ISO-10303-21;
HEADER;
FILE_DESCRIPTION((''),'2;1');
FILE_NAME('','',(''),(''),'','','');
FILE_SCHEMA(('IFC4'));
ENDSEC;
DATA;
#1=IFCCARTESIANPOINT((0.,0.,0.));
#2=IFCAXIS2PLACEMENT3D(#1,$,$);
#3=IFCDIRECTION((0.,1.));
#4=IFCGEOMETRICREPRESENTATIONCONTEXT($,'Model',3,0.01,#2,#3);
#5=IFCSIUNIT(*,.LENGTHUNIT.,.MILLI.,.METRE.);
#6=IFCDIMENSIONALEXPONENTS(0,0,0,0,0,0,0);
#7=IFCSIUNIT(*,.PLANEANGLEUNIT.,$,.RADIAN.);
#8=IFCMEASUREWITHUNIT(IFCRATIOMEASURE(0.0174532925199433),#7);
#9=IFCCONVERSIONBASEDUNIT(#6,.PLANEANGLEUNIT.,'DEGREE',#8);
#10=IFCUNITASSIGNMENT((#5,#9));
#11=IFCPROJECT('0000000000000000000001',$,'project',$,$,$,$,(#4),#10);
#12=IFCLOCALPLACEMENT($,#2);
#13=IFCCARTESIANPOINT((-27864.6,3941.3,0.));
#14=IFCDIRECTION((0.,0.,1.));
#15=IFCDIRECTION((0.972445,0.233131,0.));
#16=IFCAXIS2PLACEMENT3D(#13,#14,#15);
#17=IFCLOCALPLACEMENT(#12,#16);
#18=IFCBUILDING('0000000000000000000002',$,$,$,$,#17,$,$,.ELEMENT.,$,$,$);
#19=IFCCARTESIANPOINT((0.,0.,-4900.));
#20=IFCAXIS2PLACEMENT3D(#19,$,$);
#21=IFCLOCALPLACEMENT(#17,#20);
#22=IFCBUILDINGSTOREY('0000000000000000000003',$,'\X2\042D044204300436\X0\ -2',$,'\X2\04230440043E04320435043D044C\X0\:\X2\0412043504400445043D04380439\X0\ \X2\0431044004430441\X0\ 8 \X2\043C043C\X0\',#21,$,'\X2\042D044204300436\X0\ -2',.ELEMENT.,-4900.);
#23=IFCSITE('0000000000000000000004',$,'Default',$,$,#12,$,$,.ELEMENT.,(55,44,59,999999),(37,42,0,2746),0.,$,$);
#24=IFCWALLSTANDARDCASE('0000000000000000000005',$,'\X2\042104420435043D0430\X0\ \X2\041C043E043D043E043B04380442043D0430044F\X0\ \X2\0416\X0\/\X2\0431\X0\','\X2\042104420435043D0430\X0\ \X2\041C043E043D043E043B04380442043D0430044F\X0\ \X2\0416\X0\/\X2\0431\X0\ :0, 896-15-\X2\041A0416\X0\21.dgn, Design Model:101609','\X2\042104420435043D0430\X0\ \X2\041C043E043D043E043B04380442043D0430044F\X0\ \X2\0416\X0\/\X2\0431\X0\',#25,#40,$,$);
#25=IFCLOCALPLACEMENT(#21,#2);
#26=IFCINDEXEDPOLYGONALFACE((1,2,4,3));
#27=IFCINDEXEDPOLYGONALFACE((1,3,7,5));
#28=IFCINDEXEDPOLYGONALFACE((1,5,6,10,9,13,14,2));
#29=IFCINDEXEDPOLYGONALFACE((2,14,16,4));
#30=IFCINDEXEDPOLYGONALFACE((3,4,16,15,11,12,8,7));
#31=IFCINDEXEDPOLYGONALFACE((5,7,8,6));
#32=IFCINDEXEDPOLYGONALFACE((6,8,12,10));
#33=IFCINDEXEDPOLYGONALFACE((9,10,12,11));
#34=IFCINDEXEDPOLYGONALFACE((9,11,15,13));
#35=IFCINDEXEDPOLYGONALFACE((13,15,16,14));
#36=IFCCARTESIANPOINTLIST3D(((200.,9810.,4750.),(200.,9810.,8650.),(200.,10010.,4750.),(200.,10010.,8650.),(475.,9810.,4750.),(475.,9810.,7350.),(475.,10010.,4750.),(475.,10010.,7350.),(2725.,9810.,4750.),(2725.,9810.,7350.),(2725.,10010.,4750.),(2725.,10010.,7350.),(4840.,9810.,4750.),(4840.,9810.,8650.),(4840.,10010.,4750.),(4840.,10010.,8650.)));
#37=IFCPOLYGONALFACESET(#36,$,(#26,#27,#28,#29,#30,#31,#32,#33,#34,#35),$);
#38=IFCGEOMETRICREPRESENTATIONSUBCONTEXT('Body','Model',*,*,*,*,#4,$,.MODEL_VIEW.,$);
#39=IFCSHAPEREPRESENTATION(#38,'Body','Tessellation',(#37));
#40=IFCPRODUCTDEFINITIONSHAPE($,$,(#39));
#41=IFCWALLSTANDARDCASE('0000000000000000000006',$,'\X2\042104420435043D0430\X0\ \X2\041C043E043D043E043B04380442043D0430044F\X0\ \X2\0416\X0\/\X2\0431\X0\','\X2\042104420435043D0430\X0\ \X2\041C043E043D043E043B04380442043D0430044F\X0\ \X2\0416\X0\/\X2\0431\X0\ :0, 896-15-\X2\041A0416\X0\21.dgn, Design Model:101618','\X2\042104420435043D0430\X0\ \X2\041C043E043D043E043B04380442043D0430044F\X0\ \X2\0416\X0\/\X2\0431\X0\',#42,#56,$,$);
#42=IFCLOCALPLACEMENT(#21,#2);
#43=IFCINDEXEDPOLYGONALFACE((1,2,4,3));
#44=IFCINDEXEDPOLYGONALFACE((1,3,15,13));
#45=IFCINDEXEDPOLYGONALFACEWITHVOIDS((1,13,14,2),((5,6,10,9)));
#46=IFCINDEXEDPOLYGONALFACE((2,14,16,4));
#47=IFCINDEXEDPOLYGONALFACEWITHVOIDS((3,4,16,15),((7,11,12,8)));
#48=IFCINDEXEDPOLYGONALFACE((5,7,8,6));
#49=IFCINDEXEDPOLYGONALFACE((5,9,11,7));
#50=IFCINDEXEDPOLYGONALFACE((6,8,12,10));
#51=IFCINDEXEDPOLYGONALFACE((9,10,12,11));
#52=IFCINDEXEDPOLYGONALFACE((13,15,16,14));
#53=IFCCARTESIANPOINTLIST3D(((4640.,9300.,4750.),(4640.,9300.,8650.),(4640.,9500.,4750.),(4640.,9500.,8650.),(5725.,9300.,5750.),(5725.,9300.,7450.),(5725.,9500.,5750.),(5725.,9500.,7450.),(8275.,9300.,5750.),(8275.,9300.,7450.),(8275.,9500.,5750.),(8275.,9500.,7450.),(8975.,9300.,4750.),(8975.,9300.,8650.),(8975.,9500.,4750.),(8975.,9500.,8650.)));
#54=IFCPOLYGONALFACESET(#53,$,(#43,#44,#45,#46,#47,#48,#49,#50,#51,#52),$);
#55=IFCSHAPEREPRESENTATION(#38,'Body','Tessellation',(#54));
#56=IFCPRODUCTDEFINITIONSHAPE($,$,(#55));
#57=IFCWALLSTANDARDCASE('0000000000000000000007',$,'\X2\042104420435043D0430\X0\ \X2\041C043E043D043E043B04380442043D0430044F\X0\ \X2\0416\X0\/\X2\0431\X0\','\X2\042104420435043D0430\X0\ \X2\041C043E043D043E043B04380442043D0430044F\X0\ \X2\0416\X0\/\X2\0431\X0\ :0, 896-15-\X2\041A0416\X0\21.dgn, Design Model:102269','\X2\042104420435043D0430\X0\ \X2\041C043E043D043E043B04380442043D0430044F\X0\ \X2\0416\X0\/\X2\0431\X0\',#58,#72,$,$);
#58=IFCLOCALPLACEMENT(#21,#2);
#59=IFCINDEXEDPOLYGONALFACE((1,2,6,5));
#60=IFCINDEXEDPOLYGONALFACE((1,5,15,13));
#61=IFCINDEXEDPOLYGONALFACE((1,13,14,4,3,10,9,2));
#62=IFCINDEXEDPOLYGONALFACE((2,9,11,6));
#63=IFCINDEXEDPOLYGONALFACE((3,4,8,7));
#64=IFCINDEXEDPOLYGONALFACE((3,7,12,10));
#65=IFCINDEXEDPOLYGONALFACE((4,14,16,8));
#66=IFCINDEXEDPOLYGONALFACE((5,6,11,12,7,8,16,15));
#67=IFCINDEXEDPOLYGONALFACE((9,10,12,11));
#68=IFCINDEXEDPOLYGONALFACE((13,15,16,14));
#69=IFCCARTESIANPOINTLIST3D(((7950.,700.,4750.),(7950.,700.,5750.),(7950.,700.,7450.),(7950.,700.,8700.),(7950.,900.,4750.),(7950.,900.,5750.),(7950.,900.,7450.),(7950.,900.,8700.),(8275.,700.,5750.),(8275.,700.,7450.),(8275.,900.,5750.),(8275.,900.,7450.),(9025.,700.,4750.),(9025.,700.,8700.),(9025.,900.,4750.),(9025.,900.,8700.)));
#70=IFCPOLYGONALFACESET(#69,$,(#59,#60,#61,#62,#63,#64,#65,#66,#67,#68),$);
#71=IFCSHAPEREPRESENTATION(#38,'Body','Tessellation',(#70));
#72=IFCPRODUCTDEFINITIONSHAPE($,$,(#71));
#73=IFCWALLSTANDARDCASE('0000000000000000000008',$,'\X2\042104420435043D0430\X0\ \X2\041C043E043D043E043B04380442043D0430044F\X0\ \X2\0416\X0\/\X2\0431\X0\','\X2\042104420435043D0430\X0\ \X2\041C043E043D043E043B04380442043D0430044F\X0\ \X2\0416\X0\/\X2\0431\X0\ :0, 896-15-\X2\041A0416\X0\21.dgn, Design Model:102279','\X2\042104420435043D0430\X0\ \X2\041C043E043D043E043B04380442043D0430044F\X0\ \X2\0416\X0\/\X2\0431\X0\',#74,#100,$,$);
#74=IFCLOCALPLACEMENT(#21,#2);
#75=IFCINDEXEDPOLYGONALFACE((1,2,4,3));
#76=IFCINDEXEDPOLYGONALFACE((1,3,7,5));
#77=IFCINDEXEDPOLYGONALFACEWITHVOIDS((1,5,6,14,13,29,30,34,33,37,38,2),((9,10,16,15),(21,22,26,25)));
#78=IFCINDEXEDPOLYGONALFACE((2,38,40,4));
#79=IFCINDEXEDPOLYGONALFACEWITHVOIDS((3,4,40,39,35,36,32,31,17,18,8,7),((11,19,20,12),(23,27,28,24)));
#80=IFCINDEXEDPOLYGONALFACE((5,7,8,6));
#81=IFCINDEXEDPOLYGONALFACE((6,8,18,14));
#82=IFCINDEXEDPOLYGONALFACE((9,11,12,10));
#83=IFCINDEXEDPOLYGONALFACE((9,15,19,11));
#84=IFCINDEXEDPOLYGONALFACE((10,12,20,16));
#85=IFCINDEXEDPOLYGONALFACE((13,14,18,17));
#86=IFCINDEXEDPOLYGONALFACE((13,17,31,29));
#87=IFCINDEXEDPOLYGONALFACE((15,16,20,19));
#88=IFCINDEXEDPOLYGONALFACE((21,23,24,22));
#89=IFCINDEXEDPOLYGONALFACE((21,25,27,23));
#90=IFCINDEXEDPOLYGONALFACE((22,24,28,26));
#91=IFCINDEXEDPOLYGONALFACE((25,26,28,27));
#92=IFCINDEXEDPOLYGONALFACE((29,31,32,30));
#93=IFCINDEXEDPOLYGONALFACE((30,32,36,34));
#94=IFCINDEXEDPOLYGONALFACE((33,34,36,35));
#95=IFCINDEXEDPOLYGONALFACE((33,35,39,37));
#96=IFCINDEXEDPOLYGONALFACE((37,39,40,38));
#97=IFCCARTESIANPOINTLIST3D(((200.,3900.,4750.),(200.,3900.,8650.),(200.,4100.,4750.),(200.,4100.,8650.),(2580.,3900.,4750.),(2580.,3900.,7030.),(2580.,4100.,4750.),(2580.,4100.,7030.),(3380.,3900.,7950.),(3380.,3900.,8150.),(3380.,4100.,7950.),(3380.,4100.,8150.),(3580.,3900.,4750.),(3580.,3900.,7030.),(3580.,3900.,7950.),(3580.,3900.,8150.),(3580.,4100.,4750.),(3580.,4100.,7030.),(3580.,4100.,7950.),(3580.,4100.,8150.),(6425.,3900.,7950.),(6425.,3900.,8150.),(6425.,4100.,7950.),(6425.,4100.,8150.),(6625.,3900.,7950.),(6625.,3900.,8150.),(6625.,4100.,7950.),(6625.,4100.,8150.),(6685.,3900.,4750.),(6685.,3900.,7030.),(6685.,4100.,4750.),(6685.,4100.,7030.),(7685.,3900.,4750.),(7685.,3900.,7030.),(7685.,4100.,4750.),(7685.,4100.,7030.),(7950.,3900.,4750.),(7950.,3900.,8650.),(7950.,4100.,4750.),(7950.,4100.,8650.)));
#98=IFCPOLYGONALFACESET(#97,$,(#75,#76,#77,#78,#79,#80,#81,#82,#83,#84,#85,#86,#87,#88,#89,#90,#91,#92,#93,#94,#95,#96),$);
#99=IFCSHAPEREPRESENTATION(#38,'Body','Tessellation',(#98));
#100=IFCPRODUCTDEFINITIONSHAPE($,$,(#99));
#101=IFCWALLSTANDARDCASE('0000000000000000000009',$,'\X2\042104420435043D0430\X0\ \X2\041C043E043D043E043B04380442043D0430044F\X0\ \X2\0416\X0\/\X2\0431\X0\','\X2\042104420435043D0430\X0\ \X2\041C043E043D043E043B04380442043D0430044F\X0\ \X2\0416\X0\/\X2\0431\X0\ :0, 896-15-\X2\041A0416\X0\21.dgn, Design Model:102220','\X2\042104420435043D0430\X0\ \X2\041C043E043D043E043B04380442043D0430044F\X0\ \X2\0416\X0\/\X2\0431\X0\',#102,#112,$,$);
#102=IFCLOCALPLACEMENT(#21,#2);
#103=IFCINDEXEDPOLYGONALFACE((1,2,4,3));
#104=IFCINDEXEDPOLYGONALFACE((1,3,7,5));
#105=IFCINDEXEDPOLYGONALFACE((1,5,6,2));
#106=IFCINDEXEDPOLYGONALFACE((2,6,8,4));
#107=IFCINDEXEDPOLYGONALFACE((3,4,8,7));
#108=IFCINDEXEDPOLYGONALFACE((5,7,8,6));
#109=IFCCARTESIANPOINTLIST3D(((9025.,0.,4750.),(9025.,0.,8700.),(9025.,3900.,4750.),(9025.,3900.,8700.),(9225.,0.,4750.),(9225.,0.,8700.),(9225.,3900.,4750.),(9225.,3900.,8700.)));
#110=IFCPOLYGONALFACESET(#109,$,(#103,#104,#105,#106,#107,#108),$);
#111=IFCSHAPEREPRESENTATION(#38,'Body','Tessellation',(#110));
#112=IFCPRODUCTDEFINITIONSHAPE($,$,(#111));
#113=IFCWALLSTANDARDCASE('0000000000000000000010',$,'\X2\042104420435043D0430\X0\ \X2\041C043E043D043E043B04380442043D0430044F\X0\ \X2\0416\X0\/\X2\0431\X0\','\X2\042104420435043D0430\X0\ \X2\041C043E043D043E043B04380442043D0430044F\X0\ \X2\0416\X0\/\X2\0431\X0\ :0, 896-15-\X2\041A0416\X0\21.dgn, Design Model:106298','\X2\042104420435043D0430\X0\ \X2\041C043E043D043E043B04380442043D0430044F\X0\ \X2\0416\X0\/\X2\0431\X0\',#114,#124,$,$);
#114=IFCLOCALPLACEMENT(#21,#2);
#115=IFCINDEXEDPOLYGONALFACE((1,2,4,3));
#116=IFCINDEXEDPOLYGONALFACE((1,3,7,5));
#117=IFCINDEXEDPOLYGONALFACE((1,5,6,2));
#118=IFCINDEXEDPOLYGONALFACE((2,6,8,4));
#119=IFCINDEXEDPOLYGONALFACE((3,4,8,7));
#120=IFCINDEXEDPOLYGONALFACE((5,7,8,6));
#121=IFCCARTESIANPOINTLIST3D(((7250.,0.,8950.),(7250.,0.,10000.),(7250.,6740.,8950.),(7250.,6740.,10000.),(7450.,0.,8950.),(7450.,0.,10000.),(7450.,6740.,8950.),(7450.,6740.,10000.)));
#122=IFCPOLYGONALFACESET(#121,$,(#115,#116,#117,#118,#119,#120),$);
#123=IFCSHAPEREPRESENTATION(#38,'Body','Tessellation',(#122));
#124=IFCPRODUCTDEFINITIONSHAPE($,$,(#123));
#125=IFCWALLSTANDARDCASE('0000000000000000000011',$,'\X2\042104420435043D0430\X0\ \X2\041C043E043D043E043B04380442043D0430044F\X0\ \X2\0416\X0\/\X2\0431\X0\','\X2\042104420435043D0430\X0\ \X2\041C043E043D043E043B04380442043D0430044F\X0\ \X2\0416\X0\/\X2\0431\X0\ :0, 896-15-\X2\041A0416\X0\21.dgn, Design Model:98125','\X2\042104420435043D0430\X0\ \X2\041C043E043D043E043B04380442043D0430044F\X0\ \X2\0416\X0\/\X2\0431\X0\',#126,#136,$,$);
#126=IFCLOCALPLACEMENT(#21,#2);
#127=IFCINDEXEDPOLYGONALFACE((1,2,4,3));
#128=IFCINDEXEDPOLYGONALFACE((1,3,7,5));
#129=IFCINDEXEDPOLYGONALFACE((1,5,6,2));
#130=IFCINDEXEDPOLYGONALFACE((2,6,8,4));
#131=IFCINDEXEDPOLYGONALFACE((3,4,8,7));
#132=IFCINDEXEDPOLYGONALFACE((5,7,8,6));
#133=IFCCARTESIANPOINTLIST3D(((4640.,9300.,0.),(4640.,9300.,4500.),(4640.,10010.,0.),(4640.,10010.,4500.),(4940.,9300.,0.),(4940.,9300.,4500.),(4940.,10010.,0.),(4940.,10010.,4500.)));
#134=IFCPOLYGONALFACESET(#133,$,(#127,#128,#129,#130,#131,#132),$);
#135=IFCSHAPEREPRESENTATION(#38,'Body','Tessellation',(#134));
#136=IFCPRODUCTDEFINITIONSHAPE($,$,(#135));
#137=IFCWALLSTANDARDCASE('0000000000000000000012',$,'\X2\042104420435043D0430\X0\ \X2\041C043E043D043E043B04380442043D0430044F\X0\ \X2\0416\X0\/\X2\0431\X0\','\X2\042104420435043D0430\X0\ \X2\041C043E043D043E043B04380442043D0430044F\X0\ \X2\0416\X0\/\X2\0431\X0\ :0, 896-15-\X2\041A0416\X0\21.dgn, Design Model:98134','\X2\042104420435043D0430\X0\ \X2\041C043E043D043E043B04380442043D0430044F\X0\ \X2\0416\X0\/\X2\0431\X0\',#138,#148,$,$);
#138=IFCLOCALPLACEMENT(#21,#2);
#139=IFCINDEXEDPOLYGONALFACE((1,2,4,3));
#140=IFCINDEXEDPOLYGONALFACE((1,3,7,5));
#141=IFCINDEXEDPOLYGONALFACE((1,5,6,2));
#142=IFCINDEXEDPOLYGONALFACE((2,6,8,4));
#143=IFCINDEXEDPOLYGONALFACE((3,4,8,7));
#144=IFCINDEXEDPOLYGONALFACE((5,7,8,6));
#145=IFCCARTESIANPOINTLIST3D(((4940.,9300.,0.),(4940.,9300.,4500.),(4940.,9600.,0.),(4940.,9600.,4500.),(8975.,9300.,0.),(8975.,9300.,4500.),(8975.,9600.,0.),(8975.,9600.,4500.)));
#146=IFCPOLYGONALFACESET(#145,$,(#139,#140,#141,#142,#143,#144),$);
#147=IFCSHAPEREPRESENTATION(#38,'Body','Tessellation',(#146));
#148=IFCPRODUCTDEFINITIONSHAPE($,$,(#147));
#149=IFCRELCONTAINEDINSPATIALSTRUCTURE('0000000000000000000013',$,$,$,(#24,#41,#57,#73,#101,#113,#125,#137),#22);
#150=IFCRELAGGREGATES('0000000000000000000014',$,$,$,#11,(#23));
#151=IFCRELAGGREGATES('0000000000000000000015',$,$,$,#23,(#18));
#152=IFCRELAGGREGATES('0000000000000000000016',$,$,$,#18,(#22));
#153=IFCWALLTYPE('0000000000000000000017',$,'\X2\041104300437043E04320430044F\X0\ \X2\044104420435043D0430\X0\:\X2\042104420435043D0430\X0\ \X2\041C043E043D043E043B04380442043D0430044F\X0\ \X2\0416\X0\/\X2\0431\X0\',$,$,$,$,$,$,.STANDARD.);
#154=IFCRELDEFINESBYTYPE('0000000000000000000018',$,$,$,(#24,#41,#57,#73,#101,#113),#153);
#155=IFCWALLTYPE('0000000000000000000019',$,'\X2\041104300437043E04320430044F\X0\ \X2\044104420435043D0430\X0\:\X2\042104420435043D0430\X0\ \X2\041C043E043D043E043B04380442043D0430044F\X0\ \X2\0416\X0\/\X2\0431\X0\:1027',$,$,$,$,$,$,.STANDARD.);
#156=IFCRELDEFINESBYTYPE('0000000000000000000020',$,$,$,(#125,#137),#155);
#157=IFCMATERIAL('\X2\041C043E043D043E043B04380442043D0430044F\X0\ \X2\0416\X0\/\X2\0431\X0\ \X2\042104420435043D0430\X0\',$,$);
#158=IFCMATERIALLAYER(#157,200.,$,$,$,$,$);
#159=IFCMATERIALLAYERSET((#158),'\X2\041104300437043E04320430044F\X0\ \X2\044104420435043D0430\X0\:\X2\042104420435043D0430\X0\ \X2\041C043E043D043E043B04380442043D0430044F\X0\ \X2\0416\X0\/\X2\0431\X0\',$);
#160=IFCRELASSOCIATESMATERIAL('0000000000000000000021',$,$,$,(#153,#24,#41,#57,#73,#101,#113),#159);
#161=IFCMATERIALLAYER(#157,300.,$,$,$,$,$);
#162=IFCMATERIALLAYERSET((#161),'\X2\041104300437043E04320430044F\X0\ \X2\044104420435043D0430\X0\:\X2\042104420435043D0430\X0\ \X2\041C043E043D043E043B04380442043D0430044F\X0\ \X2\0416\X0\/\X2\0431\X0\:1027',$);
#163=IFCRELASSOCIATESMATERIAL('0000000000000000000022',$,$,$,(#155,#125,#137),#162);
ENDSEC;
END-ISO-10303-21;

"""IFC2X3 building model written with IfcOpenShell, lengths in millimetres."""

from ifc_helpers import new_model, entity, si_unit, converted_unit, direction, frame, frame_2d, origin, origin_2d_with_axis, place, context, subcontext, project, spatial, rectangle, extrude, material, layer, layer_set, layer_usage, type_object, element, save


model = new_model("IFC2X3")

# Units and contexts
model_context = context("Model", 3, precision=0.01, world=origin(), true_north=direction((0.0, 1.0)))
body_context = subcontext(model_context, "Body", "Model", "MODEL_VIEW")
ifc_project = project(units=[si_unit("LENGTHUNIT", "METRE", prefix="MILLI"), converted_unit("PLANEANGLEUNIT", "DEGREE", entity("IfcRatioMeasure", 0.0174532925199433), si_unit("PLANEANGLEUNIT", "RADIAN"), dimensions=[0, 0, 0, 0, 0, 0, 0])], contexts=[model_context])

# Site, building, storey
site_placement = place(None, origin())
site = spatial("IfcSite", under=ifc_project, at=site_placement, Name="Default", CompositionType="ELEMENT", RefLatitude=(55, 44, 59, 999999), RefLongitude=(37, 42, 0, 2746), RefElevation=0.0)
building_placement = place(site_placement, frame((-27864.6, 3941.3, 0.0), z_axis=(0.0, 0.0, 1.0), x_axis=(0.972445, 0.233131, 0.0)))
building = spatial("IfcBuilding", under=site, at=building_placement, CompositionType="ELEMENT")
storey_placement = place(building_placement, frame((0.0, 0.0, -4900.0)))
storey = spatial("IfcBuildingStorey", under=building, at=storey_placement, Name="Этаж -2", ObjectType="Уровень:Верхний брус 8 мм", LongName="Этаж -2", CompositionType="ELEMENT", Elevation=-4900.0)

# Walls, openings
ifc_material = material(Name="Монолитная Ж/б Стена")
ifc_layer_1 = layer(ifc_material, 200.0)
ifc_layer_set_1 = layer_set([ifc_layer_1], Name="Базовая стена:Стена Монолитная Ж/б")
ifc_layer_usage_1 = layer_usage(ifc_layer_set_1, "AXIS2", "NEGATIVE", 100.0)
wall_type_1 = type_object("IfcWallType", Name="Базовая стена:Стена Монолитная Ж/б", PredefinedType="STANDARD", material=ifc_layer_set_1)
wall_1_placement = place(storey_placement, frame((4840.0, 9910.0, 4750.0), z_axis=(0.0, 0.0, 1.0), x_axis=(-1.0, 0.0, 0.0)))
wall_1 = element("IfcWallStandardCase", 1, at=wall_1_placement, inside=storey, type_object=wall_type_1, material=ifc_layer_usage_1, Name="Стена Монолитная Ж/б", Description="Стена Монолитная Ж/б :0, 896-15-КЖ21.dgn, Design Model:101609", ObjectType="Стена Монолитная Ж/б", context=body_context, shape_type="SweptSolid", body=[
    extrude(rectangle(XDim=4640.0, YDim=200.0, at=frame_2d((2320.0, 0.0), x_axis=(-1.0, 0.0))), origin(), (0.0, 0.0, 1.0), 3900.0),
])
opening_1_placement = place(wall_1_placement, origin())
element("IfcOpeningElement", 2, at=opening_1_placement, cuts=wall_1, ObjectType="Opening", context=body_context, shape_type="SweptSolid", body=[
    extrude(rectangle(XDim=2600.0, YDim=2250.0, at=origin_2d_with_axis()), frame((3240.0, -100.0, 1300.0), z_axis=(0.0, 1.0, 0.0), x_axis=(0.0, 0.0, -1.0)), (0.0, 0.0, 1.0), 200.0),
])
ifc_layer_usage_2 = layer_usage(ifc_layer_set_1, "AXIS2", "NEGATIVE", 100.0)
wall_2_placement = place(storey_placement, frame((8975.0, 9400.0, 4750.0), z_axis=(0.0, 0.0, 1.0), x_axis=(-1.0, 0.0, 0.0)))
wall_2 = element("IfcWallStandardCase", 3, at=wall_2_placement, inside=storey, type_object=wall_type_1, material=ifc_layer_usage_2, Name="Стена Монолитная Ж/б", Description="Стена Монолитная Ж/б :0, 896-15-КЖ21.dgn, Design Model:101618", ObjectType="Стена Монолитная Ж/б", context=body_context, shape_type="SweptSolid", body=[
    extrude(rectangle(XDim=4335.0, YDim=200.0, at=frame_2d((2167.5, 0.0), x_axis=(-1.0, 0.0))), origin(), (0.0, 0.0, 1.0), 3900.0),
])
opening_2_placement = place(wall_2_placement, origin())
element("IfcOpeningElement", 4, at=opening_2_placement, cuts=wall_2, ObjectType="Opening", context=body_context, shape_type="SweptSolid", body=[
    extrude(rectangle(XDim=1700.0, YDim=2550.0, at=origin_2d_with_axis()), frame((1975.0, -100.0, 1850.0), z_axis=(0.0, 1.0, 0.0), x_axis=(0.0, 0.0, -1.0)), (0.0, 0.0, 1.0), 200.0),
])
ifc_layer_usage_3 = layer_usage(ifc_layer_set_1, "AXIS2", "NEGATIVE", 100.0)
wall_3_placement = place(storey_placement, frame((9025.0, 800.0, 4750.0), z_axis=(0.0, 0.0, 1.0), x_axis=(-1.0, 0.0, 0.0)))
wall_3 = element("IfcWallStandardCase", 5, at=wall_3_placement, inside=storey, type_object=wall_type_1, material=ifc_layer_usage_3, Name="Стена Монолитная Ж/б", Description="Стена Монолитная Ж/б :0, 896-15-КЖ21.dgn, Design Model:102269", ObjectType="Стена Монолитная Ж/б", context=body_context, shape_type="SweptSolid", body=[
    extrude(rectangle(XDim=1075.0, YDim=200.0, at=frame_2d((537.5, 0.0), x_axis=(-1.0, 0.0))), origin(), (0.0, 0.0, 1.0), 3950.0),
])
opening_3_placement = place(wall_3_placement, origin())
element("IfcOpeningElement", 6, at=opening_3_placement, cuts=wall_3, ObjectType="Opening", context=body_context, shape_type="SweptSolid", body=[
    extrude(rectangle(XDim=1700.0, YDim=325.0, at=frame_2d((0.0, 0.0), x_axis=(1.0, 0.0))), frame((912.5, -100.0, 1850.0), z_axis=(0.0, 1.0, 0.0), x_axis=(0.0, 0.0, -1.0)), (0.0, 0.0, 1.0), 200.0),
])

# Wall, openings
ifc_layer_usage_4 = layer_usage(ifc_layer_set_1, "AXIS2", "NEGATIVE", 100.0)
wall_4_placement = place(storey_placement, frame((7950.0, 4000.0, 4750.0), z_axis=(0.0, 0.0, 1.0), x_axis=(-1.0, 0.0, 0.0)))
wall_4 = element("IfcWallStandardCase", 7, at=wall_4_placement, inside=storey, type_object=wall_type_1, material=ifc_layer_usage_4, Name="Стена Монолитная Ж/б", Description="Стена Монолитная Ж/б :0, 896-15-КЖ21.dgn, Design Model:102279", ObjectType="Стена Монолитная Ж/б", context=body_context, shape_type="SweptSolid", body=[
    extrude(rectangle(XDim=7750.0, YDim=200.0, at=frame_2d((3875.0, 0.0), x_axis=(-1.0, 0.0))), origin(), (0.0, 0.0, 1.0), 3900.0),
])
opening_4_placement = place(wall_4_placement, origin())
element("IfcOpeningElement", 8, at=opening_4_placement, cuts=wall_4, ObjectType="Opening", context=body_context, shape_type="SweptSolid", body=[
    extrude(rectangle(XDim=2280.0, YDim=1000.0, at=origin_2d_with_axis()), frame((4870.0, -100.0, 1140.0), z_axis=(0.0, 1.0, 0.0), x_axis=(0.0, 0.0, -1.0)), (0.0, 0.0, 1.0), 200.0),
])
opening_5_placement = place(wall_4_placement, origin())
element("IfcOpeningElement", 9, at=opening_5_placement, cuts=wall_4, ObjectType="Opening", context=body_context, shape_type="SweptSolid", body=[
    extrude(rectangle(XDim=2280.0, YDim=1000.0, at=origin_2d_with_axis()), frame((765.0, -100.0, 1140.0), z_axis=(0.0, 1.0, 0.0), x_axis=(0.0, 0.0, -1.0)), (0.0, 0.0, 1.0), 200.0),
])
opening_6_placement = place(wall_4_placement, origin())
element("IfcOpeningElement", 10, at=opening_6_placement, cuts=wall_4, ObjectType="Opening", context=body_context, shape_type="SweptSolid", body=[
    extrude(rectangle(XDim=200.0, YDim=200.0, at=origin_2d_with_axis()), frame((4470.0, -100.0, 3300.0), z_axis=(0.0, 1.0, 0.0), x_axis=(0.0, 0.0, -1.0)), (0.0, 0.0, 1.0), 200.0),
])
opening_7_placement = place(wall_4_placement, origin())
element("IfcOpeningElement", 11, at=opening_7_placement, cuts=wall_4, ObjectType="Opening", context=body_context, shape_type="SweptSolid", body=[
    extrude(rectangle(XDim=200.0, YDim=200.0, at=origin_2d_with_axis()), frame((1425.0, -100.0, 3300.0), z_axis=(0.0, 1.0, 0.0), x_axis=(0.0, 0.0, -1.0)), (0.0, 0.0, 1.0), 200.0),
])

# Walls
ifc_layer_usage_5 = layer_usage(ifc_layer_set_1, "AXIS2", "NEGATIVE", 100.0)
wall_5_placement = place(storey_placement, frame((9125.0, 3900.0, 4750.0), z_axis=(0.0, 0.0, 1.0), x_axis=(0.0, -1.0, 0.0)))
element("IfcWallStandardCase", 12, at=wall_5_placement, inside=storey, type_object=wall_type_1, material=ifc_layer_usage_5, Name="Стена Монолитная Ж/б", Description="Стена Монолитная Ж/б :0, 896-15-КЖ21.dgn, Design Model:102220", ObjectType="Стена Монолитная Ж/б", context=body_context, shape_type="SweptSolid", body=[
    extrude(rectangle(XDim=3900.0, YDim=200.0, at=frame_2d((1950.0, 0.0), x_axis=(-1.0, 0.0))), origin(), (0.0, 0.0, 1.0), 3950.0),
])
ifc_layer_usage_6 = layer_usage(ifc_layer_set_1, "AXIS2", "NEGATIVE", 100.0)
wall_6_placement = place(storey_placement, frame((7350.0, 6740.0, 8950.0), z_axis=(0.0, 0.0, 1.0), x_axis=(0.0, -1.0, 0.0)))
element("IfcWallStandardCase", 13, at=wall_6_placement, inside=storey, type_object=wall_type_1, material=ifc_layer_usage_6, Name="Стена Монолитная Ж/б", Description="Стена Монолитная Ж/б :0, 896-15-КЖ21.dgn, Design Model:106298", ObjectType="Стена Монолитная Ж/б", context=body_context, shape_type="SweptSolid", body=[
    extrude(rectangle(XDim=6740.0, YDim=200.0, at=frame_2d((3370.0, 0.0), x_axis=(-1.0, 0.0))), origin(), (0.0, 0.0, 1.0), 1050.0),
])
ifc_layer_2 = layer(ifc_material, 300.0)
ifc_layer_set_2 = layer_set([ifc_layer_2], Name="Базовая стена:Стена Монолитная Ж/б:1027")
ifc_layer_usage_7 = layer_usage(ifc_layer_set_2, "AXIS2", "NEGATIVE", 150.0)
wall_type_2 = type_object("IfcWallType", Name="Базовая стена:Стена Монолитная Ж/б:1027", PredefinedType="STANDARD", material=ifc_layer_set_2)
wall_7_placement = place(storey_placement, frame((4790.0, 9300.0, 0.0), z_axis=(0.0, 0.0, 1.0), x_axis=(0.0, 1.0, 0.0)))
element("IfcWallStandardCase", 14, at=wall_7_placement, inside=storey, type_object=wall_type_2, material=ifc_layer_usage_7, Name="Стена Монолитная Ж/б", Description="Стена Монолитная Ж/б :0, 896-15-КЖ21.dgn, Design Model:98125", ObjectType="Стена Монолитная Ж/б", context=body_context, shape_type="SweptSolid", body=[
    extrude(rectangle(XDim=710.0, YDim=300.0, at=frame_2d((355.0, 0.0), x_axis=(-1.0, 0.0))), origin(), (0.0, 0.0, 1.0), 4500.0),
])
ifc_layer_usage_8 = layer_usage(ifc_layer_set_2, "AXIS2", "NEGATIVE", 150.0)
wall_8_placement = place(storey_placement, frame((8975.0, 9450.0, 0.0), z_axis=(0.0, 0.0, 1.0), x_axis=(-1.0, 0.0, 0.0)))
element("IfcWallStandardCase", 15, at=wall_8_placement, inside=storey, type_object=wall_type_2, material=ifc_layer_usage_8, Name="Стена Монолитная Ж/б", Description="Стена Монолитная Ж/б :0, 896-15-КЖ21.dgn, Design Model:98134", ObjectType="Стена Монолитная Ж/б", context=body_context, shape_type="SweptSolid", body=[
    extrude(rectangle(XDim=4035.0, YDim=300.0, at=frame_2d((2017.5, 0.0), x_axis=(-1.0, 0.0))), origin(), (0.0, 0.0, 1.0), 4500.0),
])

save(model, "model.ifc")
